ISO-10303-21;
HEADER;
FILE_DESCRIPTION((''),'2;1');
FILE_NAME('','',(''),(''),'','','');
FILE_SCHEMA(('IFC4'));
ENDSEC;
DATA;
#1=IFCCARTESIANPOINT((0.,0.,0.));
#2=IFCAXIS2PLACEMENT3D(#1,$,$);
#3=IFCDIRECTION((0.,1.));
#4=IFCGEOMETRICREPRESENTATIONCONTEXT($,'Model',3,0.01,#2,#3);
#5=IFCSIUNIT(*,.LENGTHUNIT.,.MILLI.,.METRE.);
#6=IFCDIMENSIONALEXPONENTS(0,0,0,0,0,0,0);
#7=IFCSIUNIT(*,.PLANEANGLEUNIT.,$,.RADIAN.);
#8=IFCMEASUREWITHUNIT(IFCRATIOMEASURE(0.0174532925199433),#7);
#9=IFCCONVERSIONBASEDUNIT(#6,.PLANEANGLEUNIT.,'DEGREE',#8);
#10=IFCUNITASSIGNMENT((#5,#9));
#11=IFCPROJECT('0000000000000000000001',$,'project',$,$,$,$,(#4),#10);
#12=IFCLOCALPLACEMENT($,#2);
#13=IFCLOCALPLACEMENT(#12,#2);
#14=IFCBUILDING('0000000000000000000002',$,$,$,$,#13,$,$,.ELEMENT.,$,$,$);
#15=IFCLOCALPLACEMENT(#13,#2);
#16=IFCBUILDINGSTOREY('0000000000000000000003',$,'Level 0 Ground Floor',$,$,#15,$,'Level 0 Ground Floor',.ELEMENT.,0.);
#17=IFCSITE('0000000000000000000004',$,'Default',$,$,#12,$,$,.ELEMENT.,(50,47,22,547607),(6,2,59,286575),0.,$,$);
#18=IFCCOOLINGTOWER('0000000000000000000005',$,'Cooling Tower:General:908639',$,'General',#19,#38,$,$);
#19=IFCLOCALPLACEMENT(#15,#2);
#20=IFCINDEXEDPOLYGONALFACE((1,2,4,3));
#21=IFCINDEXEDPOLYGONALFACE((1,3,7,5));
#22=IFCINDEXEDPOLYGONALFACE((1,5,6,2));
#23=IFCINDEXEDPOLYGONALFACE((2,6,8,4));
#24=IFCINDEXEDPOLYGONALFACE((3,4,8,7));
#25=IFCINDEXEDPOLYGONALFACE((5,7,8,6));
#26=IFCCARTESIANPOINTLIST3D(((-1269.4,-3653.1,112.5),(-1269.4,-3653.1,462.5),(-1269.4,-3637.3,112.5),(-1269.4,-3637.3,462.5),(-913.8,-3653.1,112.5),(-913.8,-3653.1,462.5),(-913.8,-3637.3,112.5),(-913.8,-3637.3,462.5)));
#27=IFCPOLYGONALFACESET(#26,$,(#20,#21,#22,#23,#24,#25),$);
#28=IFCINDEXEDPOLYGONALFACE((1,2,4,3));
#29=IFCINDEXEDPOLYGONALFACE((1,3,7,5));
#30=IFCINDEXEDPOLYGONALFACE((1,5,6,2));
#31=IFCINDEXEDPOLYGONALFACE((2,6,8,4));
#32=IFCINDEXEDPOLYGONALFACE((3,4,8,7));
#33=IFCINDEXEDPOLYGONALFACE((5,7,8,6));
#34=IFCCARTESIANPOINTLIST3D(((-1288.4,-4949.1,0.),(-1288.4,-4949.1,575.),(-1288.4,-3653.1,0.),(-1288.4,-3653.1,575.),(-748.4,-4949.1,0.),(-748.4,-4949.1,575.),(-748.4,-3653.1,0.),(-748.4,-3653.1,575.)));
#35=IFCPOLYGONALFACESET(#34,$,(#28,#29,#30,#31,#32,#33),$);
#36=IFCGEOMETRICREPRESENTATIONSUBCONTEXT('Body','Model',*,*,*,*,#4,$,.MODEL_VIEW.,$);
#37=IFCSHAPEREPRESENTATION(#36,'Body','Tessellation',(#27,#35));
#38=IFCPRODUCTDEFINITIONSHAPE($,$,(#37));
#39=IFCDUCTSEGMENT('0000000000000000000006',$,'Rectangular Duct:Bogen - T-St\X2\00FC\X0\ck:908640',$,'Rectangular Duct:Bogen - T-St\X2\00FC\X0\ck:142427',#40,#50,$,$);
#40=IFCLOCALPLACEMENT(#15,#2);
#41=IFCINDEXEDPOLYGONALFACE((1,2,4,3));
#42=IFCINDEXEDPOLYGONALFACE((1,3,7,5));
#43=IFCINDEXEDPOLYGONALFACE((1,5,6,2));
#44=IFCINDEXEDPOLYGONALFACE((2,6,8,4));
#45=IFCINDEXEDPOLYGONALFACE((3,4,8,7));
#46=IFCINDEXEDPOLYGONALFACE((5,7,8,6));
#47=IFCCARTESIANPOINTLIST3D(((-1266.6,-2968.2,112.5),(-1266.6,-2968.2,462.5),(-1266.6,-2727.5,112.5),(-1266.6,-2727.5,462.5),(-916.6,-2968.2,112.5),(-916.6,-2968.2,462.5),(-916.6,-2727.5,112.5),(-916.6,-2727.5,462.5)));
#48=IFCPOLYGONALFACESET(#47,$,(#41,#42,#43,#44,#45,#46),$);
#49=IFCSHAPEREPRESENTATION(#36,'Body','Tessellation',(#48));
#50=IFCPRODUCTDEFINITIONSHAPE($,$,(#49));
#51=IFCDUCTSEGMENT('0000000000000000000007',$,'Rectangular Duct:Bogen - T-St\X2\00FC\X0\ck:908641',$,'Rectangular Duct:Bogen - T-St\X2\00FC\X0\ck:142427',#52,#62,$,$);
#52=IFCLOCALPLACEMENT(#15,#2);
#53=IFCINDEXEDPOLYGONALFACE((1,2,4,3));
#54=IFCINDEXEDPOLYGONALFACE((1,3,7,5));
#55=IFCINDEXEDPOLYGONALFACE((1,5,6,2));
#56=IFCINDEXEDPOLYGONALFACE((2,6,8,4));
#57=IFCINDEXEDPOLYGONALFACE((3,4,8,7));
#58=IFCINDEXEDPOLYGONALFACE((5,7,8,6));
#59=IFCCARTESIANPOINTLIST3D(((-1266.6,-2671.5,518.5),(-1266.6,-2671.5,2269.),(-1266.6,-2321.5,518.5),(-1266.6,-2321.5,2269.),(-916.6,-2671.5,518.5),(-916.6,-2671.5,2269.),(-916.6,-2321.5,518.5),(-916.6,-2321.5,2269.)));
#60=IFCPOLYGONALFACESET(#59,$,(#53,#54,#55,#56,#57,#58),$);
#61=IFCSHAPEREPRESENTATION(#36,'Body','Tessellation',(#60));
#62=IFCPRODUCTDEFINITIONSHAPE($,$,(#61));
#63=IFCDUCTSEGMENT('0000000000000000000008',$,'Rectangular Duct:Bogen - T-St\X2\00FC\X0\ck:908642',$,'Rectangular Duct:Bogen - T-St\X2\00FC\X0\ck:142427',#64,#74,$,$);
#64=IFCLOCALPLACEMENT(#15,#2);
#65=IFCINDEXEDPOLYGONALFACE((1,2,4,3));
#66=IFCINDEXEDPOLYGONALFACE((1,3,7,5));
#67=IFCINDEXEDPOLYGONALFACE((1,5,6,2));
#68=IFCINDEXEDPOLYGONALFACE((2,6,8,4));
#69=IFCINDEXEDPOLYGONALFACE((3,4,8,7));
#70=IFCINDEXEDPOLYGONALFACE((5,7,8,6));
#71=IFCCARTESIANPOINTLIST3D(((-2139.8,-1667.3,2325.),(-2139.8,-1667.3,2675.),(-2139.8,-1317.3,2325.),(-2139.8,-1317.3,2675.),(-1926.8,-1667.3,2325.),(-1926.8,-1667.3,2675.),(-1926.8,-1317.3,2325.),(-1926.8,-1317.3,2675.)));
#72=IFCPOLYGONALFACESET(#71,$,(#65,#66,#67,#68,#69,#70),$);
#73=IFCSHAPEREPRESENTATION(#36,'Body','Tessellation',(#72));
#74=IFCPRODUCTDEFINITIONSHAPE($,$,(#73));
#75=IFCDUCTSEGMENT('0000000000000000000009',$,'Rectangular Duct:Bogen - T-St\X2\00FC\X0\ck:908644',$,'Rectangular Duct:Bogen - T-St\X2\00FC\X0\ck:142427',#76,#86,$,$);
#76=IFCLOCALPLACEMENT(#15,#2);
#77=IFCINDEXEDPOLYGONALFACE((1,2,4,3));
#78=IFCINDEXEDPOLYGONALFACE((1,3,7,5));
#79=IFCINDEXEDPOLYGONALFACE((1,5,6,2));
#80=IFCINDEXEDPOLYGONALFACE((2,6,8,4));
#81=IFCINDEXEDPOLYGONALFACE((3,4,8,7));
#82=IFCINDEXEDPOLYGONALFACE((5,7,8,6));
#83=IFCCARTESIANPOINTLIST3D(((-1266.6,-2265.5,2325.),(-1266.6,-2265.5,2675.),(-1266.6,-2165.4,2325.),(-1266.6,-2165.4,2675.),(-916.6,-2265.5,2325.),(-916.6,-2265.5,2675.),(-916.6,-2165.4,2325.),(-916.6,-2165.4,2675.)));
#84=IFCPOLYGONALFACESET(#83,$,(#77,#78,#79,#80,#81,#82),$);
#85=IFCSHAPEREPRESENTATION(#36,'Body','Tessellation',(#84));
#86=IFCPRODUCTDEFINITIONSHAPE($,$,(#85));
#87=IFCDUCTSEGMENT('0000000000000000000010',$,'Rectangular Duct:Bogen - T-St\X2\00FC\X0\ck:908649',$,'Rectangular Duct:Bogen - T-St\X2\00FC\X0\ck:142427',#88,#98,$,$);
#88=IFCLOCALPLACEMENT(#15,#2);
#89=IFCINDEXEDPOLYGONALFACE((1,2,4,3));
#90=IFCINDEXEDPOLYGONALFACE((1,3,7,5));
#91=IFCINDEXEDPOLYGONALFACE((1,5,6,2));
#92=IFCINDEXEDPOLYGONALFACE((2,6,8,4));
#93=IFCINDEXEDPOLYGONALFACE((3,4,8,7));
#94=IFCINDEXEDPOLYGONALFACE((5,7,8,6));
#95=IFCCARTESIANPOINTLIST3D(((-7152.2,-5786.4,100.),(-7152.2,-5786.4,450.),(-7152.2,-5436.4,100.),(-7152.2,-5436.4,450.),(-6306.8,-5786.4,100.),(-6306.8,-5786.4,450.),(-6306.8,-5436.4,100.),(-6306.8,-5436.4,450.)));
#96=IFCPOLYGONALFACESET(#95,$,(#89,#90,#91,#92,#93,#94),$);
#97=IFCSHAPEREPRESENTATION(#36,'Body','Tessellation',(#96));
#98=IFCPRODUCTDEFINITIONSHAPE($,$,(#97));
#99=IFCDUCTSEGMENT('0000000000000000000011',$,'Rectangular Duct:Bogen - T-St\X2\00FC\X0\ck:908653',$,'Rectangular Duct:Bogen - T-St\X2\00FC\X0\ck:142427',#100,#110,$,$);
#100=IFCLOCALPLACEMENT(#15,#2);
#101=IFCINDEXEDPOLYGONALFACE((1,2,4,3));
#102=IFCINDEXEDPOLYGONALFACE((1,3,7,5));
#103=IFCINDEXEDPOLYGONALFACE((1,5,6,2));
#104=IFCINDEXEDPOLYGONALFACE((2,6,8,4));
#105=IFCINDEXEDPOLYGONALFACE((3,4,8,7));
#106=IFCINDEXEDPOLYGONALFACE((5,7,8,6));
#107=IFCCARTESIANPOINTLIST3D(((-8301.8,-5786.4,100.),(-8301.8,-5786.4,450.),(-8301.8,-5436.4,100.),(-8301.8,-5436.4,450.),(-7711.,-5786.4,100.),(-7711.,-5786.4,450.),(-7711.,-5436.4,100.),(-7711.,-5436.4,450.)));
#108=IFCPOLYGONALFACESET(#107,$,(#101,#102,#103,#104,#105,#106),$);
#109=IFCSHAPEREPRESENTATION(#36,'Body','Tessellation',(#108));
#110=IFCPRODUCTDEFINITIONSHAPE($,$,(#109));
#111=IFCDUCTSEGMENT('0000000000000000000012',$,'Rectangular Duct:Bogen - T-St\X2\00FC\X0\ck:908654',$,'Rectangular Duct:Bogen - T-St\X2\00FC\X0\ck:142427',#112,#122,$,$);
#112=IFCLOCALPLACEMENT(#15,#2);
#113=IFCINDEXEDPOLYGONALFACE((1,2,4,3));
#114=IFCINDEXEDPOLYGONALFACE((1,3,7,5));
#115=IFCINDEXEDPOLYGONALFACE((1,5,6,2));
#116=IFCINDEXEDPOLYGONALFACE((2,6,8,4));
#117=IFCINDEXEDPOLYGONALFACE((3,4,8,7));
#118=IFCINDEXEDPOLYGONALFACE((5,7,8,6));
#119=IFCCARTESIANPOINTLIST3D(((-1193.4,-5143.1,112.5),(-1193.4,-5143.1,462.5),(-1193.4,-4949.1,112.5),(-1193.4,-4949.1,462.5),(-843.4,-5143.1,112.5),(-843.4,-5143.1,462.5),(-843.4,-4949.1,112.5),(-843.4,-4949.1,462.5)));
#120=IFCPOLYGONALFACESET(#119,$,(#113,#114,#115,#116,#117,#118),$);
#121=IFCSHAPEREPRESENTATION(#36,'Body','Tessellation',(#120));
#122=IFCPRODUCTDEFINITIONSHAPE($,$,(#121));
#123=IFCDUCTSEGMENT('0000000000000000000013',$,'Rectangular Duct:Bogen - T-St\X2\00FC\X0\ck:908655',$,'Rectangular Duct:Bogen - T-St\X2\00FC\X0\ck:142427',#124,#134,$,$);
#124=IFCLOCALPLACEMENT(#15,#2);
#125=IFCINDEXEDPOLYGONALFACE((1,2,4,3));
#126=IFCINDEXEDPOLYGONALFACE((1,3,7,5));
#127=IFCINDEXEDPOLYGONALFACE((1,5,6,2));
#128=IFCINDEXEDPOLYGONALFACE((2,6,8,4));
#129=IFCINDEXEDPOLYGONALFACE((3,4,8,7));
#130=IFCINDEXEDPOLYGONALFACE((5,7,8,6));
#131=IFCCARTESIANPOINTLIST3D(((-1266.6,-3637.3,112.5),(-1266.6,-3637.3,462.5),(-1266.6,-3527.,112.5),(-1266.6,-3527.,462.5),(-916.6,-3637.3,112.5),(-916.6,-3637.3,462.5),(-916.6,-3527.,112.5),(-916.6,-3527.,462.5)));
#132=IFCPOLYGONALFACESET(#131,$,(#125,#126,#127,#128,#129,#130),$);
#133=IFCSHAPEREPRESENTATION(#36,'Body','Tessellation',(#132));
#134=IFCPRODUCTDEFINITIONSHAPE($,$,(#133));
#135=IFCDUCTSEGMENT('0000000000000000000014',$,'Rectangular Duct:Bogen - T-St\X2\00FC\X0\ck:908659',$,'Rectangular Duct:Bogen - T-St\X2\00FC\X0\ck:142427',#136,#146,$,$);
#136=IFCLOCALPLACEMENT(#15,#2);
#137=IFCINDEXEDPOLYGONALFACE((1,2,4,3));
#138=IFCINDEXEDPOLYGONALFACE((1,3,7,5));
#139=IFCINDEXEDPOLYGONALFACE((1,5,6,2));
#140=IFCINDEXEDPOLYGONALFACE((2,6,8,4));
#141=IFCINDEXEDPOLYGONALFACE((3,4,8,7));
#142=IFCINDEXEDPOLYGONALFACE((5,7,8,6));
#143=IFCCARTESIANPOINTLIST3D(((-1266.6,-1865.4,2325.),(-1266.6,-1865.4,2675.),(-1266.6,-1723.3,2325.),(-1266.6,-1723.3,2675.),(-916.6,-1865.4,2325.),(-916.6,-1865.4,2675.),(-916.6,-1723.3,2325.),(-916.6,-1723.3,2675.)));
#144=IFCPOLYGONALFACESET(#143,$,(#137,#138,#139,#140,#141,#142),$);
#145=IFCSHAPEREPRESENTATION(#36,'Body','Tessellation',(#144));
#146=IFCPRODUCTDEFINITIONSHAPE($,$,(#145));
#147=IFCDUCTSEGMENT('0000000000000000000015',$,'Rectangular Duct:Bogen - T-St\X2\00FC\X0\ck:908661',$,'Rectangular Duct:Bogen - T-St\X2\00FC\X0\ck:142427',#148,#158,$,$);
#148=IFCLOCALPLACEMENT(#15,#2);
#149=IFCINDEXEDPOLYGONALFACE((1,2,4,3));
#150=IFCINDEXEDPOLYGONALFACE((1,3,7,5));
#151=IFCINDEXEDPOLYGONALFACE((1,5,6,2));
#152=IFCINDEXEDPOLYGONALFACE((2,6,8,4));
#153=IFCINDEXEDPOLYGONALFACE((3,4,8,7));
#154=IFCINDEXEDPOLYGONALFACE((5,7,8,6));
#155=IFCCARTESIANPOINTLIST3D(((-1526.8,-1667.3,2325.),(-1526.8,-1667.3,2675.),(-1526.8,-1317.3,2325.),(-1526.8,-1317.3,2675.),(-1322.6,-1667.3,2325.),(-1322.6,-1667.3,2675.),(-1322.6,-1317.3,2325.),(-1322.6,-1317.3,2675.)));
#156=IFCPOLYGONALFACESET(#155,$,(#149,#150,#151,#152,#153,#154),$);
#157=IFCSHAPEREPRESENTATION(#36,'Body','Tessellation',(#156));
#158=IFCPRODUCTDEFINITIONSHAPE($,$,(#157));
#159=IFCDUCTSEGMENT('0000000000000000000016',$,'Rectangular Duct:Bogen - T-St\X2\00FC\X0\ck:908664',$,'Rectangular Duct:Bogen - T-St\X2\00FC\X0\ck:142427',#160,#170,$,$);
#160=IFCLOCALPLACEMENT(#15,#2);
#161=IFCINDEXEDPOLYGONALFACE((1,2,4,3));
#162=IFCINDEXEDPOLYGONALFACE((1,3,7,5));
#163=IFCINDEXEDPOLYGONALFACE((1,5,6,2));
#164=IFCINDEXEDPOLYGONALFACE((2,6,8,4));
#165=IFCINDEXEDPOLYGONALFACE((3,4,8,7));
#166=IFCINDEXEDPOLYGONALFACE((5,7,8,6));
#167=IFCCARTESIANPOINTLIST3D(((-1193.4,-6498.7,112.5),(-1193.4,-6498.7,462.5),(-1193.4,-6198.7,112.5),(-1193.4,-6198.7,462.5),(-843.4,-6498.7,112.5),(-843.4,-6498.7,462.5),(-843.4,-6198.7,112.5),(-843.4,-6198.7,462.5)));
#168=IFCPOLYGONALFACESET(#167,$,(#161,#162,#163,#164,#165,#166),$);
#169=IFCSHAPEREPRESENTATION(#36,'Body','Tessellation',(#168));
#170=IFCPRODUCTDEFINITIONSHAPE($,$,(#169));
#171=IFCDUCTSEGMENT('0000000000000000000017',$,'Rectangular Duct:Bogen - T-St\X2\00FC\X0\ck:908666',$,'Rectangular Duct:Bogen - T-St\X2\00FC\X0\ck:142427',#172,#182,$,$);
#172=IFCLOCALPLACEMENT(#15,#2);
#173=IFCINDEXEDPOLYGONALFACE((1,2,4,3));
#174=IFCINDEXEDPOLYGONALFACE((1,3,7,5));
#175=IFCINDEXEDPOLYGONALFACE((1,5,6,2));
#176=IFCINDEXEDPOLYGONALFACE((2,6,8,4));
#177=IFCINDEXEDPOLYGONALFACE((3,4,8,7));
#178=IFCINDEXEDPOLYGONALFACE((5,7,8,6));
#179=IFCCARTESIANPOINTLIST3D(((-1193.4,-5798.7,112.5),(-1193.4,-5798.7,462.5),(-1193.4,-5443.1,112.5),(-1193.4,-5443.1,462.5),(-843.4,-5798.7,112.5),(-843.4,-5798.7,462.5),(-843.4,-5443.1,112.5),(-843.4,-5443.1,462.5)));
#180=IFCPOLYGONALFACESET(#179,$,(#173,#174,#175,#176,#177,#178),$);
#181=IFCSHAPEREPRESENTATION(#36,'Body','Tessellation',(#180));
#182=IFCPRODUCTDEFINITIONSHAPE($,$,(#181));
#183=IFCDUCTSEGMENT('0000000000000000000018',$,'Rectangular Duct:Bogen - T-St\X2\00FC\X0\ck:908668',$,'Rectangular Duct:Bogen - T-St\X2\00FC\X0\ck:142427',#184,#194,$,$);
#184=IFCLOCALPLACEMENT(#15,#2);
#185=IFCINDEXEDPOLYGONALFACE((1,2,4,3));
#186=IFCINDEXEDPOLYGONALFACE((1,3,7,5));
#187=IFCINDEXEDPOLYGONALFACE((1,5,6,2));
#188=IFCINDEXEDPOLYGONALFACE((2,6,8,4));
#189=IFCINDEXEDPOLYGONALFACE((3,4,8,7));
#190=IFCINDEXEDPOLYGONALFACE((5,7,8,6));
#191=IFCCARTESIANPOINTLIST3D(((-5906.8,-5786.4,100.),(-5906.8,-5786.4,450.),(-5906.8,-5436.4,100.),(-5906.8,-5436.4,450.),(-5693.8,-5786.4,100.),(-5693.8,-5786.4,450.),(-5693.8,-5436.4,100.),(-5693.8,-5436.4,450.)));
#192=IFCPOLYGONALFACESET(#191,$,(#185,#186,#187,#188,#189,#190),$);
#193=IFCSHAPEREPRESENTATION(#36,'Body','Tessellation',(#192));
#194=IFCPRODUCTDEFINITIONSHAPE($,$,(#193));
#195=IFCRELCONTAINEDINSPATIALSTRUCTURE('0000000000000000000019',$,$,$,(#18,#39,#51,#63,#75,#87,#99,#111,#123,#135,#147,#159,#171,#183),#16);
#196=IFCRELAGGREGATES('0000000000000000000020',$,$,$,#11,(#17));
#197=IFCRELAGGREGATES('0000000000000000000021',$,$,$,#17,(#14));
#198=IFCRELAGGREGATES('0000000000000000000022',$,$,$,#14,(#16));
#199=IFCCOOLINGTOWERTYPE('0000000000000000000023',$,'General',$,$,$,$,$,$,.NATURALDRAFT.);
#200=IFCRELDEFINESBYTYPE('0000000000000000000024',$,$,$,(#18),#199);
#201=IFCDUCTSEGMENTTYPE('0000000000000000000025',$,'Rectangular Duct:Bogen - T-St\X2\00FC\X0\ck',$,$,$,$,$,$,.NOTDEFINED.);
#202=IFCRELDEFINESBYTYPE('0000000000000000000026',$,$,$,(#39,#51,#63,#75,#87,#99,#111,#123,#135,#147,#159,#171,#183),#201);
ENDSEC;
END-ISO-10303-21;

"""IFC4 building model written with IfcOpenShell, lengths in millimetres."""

from ifc_helpers import new_model, entity, si_unit, converted_unit, direction, frame, frame_2d, origin, origin_2d_with_axis, place, context, subcontext, project, spatial, rectangle, extrude, source, transform, mapped, type_object, type_shapes, element, save


model = new_model("IFC4")

# Units and contexts
model_context = context("Model", 3, precision=0.01, world=origin(), true_north=direction((0.0, 1.0)))
body_context = subcontext(model_context, "Body", "Model", "MODEL_VIEW")
ifc_project = project(units=[si_unit("LENGTHUNIT", "METRE", prefix="MILLI"), converted_unit("PLANEANGLEUNIT", "DEGREE", entity("IfcRatioMeasure", 0.0174532925199433), si_unit("PLANEANGLEUNIT", "RADIAN"), dimensions=[0, 0, 0, 0, 0, 0, 0])], contexts=[model_context])

# Site, building, storey
site_placement = place(None, origin())
site = spatial("IfcSite", under=ifc_project, at=site_placement, Name="Default", CompositionType="ELEMENT", RefLatitude=(50, 47, 22, 547607), RefLongitude=(6, 2, 59, 286575), RefElevation=0.0)
building_placement = place(site_placement, origin())
building = spatial("IfcBuilding", under=site, at=building_placement, CompositionType="ELEMENT")
storey_placement = place(building_placement, origin())
storey = spatial("IfcBuildingStorey", under=building, at=storey_placement, Name="Level 0 Ground Floor", LongName="Level 0 Ground Floor", CompositionType="ELEMENT", Elevation=0.0)

# Cooling tower
cooling_tower_type = type_object("IfcCoolingTowerType", Name="General", PredefinedType="NATURALDRAFT")
shared_shape_1 = source(origin(), body_context, "Body", "SweptSolid", [
    extrude(rectangle(XDim=15.9, YDim=355.6, at=origin_2d_with_axis()), frame((1303.9, 343.2, 112.5)), (0.0, 0.0, 1.0), 350.0),
    extrude(rectangle(XDim=1296.0, YDim=540.0, at=origin_2d_with_axis()), frame((648.0, 270.0, 0.0), z_axis=(0.0, 0.0, 1.0), x_axis=(-1.0, 0.0, 0.0)), (0.0, 0.0, 1.0), 575.0),
])
type_shapes(cooling_tower_type, [shared_shape_1])
cooling_tower_placement = place(storey_placement, frame((-748.4, -4949.1, 0.0), z_axis=(0.0, 0.0, 1.0), x_axis=(0.0, 1.0, 0.0)))
element("IfcCoolingTower", 1, at=cooling_tower_placement, inside=storey, type_object=cooling_tower_type, Name="Cooling Tower:General:908639", ObjectType="General", context=body_context, shape_type="MappedRepresentation", body=[
    mapped(shared_shape_1, transform((0.0, 0.0, 0.0), scale=1.0)),
])

# Duct segments
duct_segment_type = type_object("IfcDuctSegmentType", Name="Rectangular Duct:Bogen - T-Stück", PredefinedType="NOTDEFINED")
duct_segment_1_placement = place(storey_placement, frame((-1266.6, -2968.2, 112.5)))
element("IfcDuctSegment", 2, at=duct_segment_1_placement, inside=storey, type_object=duct_segment_type, Name="Rectangular Duct:Bogen - T-Stück:908640", ObjectType="Rectangular Duct:Bogen - T-Stück:142427", context=body_context, shape_type="SweptSolid", body=[
    extrude(rectangle(XDim=240.7, YDim=350.0, at=origin_2d_with_axis()), frame((175.0, 120.4, 0.0), z_axis=(0.0, 0.0, 1.0), x_axis=(0.0, -1.0, 0.0)), (0.0, 0.0, 1.0), 350.0),
])
duct_segment_2_placement = place(storey_placement, frame((-1266.6, -2671.5, 518.5)))
element("IfcDuctSegment", 3, at=duct_segment_2_placement, inside=storey, type_object=duct_segment_type, Name="Rectangular Duct:Bogen - T-Stück:908641", ObjectType="Rectangular Duct:Bogen - T-Stück:142427", context=body_context, shape_type="SweptSolid", body=[
    extrude(rectangle(XDim=350.0, YDim=350.0, at=frame_2d((0.0, 0.0), x_axis=(1.0, 0.0))), frame((175.0, 175.0, 0.0), z_axis=(0.0, 0.0, 1.0), x_axis=(-1.0, 0.0, 0.0)), (0.0, 0.0, 1.0), 1750.5),
])
duct_segment_3_placement = place(storey_placement, frame((-2139.8, -1667.3, 2325.0)))
element("IfcDuctSegment", 4, at=duct_segment_3_placement, inside=storey, type_object=duct_segment_type, Name="Rectangular Duct:Bogen - T-Stück:908642", ObjectType="Rectangular Duct:Bogen - T-Stück:142427", context=body_context, shape_type="SweptSolid", body=[
    extrude(rectangle(XDim=213.0, YDim=350.0, at=frame_2d((0.0, 0.0), x_axis=(1.0, 0.0))), frame((106.5, 175.0, 0.0), z_axis=(0.0, 0.0, 1.0), x_axis=(-1.0, 0.0, 0.0)), (0.0, 0.0, 1.0), 350.0),
])
duct_segment_4_placement = place(storey_placement, frame((-1266.6, -2265.5, 2325.0)))
element("IfcDuctSegment", 5, at=duct_segment_4_placement, inside=storey, type_object=duct_segment_type, Name="Rectangular Duct:Bogen - T-Stück:908644", ObjectType="Rectangular Duct:Bogen - T-Stück:142427", context=body_context, shape_type="SweptSolid", body=[
    extrude(rectangle(XDim=100.1, YDim=350.0, at=frame_2d((0.0, 0.0), x_axis=(1.0, 0.0))), frame((175.0, 50.1, 0.0), z_axis=(0.0, 0.0, 1.0), x_axis=(0.0, -1.0, 0.0)), (0.0, 0.0, 1.0), 350.0),
])
duct_segment_5_placement = place(storey_placement, frame((-7152.2, -5786.4, 100.0)))
element("IfcDuctSegment", 6, at=duct_segment_5_placement, inside=storey, type_object=duct_segment_type, Name="Rectangular Duct:Bogen - T-Stück:908649", ObjectType="Rectangular Duct:Bogen - T-Stück:142427", context=body_context, shape_type="SweptSolid", body=[
    extrude(rectangle(XDim=845.4, YDim=350.0, at=frame_2d((0.0, 0.0), x_axis=(1.0, 0.0))), frame((422.7, 175.0, 0.0), z_axis=(0.0, 0.0, 1.0), x_axis=(-1.0, 0.0, 0.0)), (0.0, 0.0, 1.0), 350.0),
])
duct_segment_6_placement = place(storey_placement, frame((-8301.8, -5786.4, 100.0)))
element("IfcDuctSegment", 7, at=duct_segment_6_placement, inside=storey, type_object=duct_segment_type, Name="Rectangular Duct:Bogen - T-Stück:908653", ObjectType="Rectangular Duct:Bogen - T-Stück:142427", context=body_context, shape_type="SweptSolid", body=[
    extrude(rectangle(XDim=590.8, YDim=350.0, at=origin_2d_with_axis()), frame((295.4, 175.0, 0.0)), (0.0, 0.0, 1.0), 350.0),
])
duct_segment_7_placement = place(storey_placement, frame((-1193.4, -5143.1, 112.5)))
element("IfcDuctSegment", 8, at=duct_segment_7_placement, inside=storey, type_object=duct_segment_type, Name="Rectangular Duct:Bogen - T-Stück:908654", ObjectType="Rectangular Duct:Bogen - T-Stück:142427", context=body_context, shape_type="SweptSolid", body=[
    extrude(rectangle(XDim=194.0, YDim=350.0, at=frame_2d((0.0, 0.0), x_axis=(1.0, 0.0))), frame((175.0, 97.0, 0.0), z_axis=(0.0, 0.0, 1.0), x_axis=(0.0, 1.0, 0.0)), (0.0, 0.0, 1.0), 350.0),
])
duct_segment_8_placement = place(storey_placement, frame((-1266.6, -3637.3, 112.5)))
element("IfcDuctSegment", 9, at=duct_segment_8_placement, inside=storey, type_object=duct_segment_type, Name="Rectangular Duct:Bogen - T-Stück:908655", ObjectType="Rectangular Duct:Bogen - T-Stück:142427", context=body_context, shape_type="SweptSolid", body=[
    extrude(rectangle(XDim=110.2, YDim=350.0, at=frame_2d((0.0, 0.0), x_axis=(1.0, 0.0))), frame((175.0, 55.1, 0.0), z_axis=(0.0, 0.0, 1.0), x_axis=(0.0, 1.0, 0.0)), (0.0, 0.0, 1.0), 350.0),
])
duct_segment_9_placement = place(storey_placement, frame((-1266.6, -1865.4, 2325.0)))
element("IfcDuctSegment", 10, at=duct_segment_9_placement, inside=storey, type_object=duct_segment_type, Name="Rectangular Duct:Bogen - T-Stück:908659", ObjectType="Rectangular Duct:Bogen - T-Stück:142427", context=body_context, shape_type="SweptSolid", body=[
    extrude(rectangle(XDim=142.1, YDim=350.0, at=origin_2d_with_axis()), frame((175.0, 71.0, 0.0), z_axis=(0.0, 0.0, 1.0), x_axis=(0.0, -1.0, 0.0)), (0.0, 0.0, 1.0), 350.0),
])
duct_segment_10_placement = place(storey_placement, frame((-1526.8, -1667.3, 2325.0)))
element("IfcDuctSegment", 11, at=duct_segment_10_placement, inside=storey, type_object=duct_segment_type, Name="Rectangular Duct:Bogen - T-Stück:908661", ObjectType="Rectangular Duct:Bogen - T-Stück:142427", context=body_context, shape_type="SweptSolid", body=[
    extrude(rectangle(XDim=204.2, YDim=350.0, at=frame_2d((0.0, 0.0), x_axis=(1.0, 0.0))), frame((102.1, 175.0, 0.0), z_axis=(0.0, 0.0, 1.0), x_axis=(-1.0, 0.0, 0.0)), (0.0, 0.0, 1.0), 350.0),
])
duct_segment_11_placement = place(storey_placement, frame((-1193.4, -6498.7, 112.5)))
element("IfcDuctSegment", 12, at=duct_segment_11_placement, inside=storey, type_object=duct_segment_type, Name="Rectangular Duct:Bogen - T-Stück:908664", ObjectType="Rectangular Duct:Bogen - T-Stück:142427", context=body_context, shape_type="SweptSolid", body=[
    extrude(rectangle(XDim=300.0, YDim=350.0, at=frame_2d((0.0, 0.0), x_axis=(1.0, 0.0))), frame((175.0, 150.0, 0.0), z_axis=(0.0, 0.0, 1.0), x_axis=(0.0, 1.0, 0.0)), (0.0, 0.0, 1.0), 350.0),
])
duct_segment_12_placement = place(storey_placement, frame((-1193.4, -5798.7, 112.5)))
element("IfcDuctSegment", 13, at=duct_segment_12_placement, inside=storey, type_object=duct_segment_type, Name="Rectangular Duct:Bogen - T-Stück:908666", ObjectType="Rectangular Duct:Bogen - T-Stück:142427", context=body_context, shape_type="SweptSolid", body=[
    extrude(rectangle(XDim=355.6, YDim=350.0, at=frame_2d((0.0, 0.0), x_axis=(1.0, 0.0))), frame((175.0, 177.8, 0.0), z_axis=(0.0, 0.0, 1.0), x_axis=(0.0, 1.0, 0.0)), (0.0, 0.0, 1.0), 350.0),
])
duct_segment_13_placement = place(storey_placement, frame((-5906.8, -5786.4, 100.0)))
element("IfcDuctSegment", 14, at=duct_segment_13_placement, inside=storey, type_object=duct_segment_type, Name="Rectangular Duct:Bogen - T-Stück:908668", ObjectType="Rectangular Duct:Bogen - T-Stück:142427", context=body_context, shape_type="SweptSolid", body=[
    extrude(rectangle(XDim=213.0, YDim=350.0, at=frame_2d((0.0, 0.0), x_axis=(1.0, 0.0))), frame((106.5, 175.0, 0.0), z_axis=(0.0, 0.0, 1.0), x_axis=(-1.0, 0.0, 0.0)), (0.0, 0.0, 1.0), 350.0),
])

save(model, "model.ifc")
